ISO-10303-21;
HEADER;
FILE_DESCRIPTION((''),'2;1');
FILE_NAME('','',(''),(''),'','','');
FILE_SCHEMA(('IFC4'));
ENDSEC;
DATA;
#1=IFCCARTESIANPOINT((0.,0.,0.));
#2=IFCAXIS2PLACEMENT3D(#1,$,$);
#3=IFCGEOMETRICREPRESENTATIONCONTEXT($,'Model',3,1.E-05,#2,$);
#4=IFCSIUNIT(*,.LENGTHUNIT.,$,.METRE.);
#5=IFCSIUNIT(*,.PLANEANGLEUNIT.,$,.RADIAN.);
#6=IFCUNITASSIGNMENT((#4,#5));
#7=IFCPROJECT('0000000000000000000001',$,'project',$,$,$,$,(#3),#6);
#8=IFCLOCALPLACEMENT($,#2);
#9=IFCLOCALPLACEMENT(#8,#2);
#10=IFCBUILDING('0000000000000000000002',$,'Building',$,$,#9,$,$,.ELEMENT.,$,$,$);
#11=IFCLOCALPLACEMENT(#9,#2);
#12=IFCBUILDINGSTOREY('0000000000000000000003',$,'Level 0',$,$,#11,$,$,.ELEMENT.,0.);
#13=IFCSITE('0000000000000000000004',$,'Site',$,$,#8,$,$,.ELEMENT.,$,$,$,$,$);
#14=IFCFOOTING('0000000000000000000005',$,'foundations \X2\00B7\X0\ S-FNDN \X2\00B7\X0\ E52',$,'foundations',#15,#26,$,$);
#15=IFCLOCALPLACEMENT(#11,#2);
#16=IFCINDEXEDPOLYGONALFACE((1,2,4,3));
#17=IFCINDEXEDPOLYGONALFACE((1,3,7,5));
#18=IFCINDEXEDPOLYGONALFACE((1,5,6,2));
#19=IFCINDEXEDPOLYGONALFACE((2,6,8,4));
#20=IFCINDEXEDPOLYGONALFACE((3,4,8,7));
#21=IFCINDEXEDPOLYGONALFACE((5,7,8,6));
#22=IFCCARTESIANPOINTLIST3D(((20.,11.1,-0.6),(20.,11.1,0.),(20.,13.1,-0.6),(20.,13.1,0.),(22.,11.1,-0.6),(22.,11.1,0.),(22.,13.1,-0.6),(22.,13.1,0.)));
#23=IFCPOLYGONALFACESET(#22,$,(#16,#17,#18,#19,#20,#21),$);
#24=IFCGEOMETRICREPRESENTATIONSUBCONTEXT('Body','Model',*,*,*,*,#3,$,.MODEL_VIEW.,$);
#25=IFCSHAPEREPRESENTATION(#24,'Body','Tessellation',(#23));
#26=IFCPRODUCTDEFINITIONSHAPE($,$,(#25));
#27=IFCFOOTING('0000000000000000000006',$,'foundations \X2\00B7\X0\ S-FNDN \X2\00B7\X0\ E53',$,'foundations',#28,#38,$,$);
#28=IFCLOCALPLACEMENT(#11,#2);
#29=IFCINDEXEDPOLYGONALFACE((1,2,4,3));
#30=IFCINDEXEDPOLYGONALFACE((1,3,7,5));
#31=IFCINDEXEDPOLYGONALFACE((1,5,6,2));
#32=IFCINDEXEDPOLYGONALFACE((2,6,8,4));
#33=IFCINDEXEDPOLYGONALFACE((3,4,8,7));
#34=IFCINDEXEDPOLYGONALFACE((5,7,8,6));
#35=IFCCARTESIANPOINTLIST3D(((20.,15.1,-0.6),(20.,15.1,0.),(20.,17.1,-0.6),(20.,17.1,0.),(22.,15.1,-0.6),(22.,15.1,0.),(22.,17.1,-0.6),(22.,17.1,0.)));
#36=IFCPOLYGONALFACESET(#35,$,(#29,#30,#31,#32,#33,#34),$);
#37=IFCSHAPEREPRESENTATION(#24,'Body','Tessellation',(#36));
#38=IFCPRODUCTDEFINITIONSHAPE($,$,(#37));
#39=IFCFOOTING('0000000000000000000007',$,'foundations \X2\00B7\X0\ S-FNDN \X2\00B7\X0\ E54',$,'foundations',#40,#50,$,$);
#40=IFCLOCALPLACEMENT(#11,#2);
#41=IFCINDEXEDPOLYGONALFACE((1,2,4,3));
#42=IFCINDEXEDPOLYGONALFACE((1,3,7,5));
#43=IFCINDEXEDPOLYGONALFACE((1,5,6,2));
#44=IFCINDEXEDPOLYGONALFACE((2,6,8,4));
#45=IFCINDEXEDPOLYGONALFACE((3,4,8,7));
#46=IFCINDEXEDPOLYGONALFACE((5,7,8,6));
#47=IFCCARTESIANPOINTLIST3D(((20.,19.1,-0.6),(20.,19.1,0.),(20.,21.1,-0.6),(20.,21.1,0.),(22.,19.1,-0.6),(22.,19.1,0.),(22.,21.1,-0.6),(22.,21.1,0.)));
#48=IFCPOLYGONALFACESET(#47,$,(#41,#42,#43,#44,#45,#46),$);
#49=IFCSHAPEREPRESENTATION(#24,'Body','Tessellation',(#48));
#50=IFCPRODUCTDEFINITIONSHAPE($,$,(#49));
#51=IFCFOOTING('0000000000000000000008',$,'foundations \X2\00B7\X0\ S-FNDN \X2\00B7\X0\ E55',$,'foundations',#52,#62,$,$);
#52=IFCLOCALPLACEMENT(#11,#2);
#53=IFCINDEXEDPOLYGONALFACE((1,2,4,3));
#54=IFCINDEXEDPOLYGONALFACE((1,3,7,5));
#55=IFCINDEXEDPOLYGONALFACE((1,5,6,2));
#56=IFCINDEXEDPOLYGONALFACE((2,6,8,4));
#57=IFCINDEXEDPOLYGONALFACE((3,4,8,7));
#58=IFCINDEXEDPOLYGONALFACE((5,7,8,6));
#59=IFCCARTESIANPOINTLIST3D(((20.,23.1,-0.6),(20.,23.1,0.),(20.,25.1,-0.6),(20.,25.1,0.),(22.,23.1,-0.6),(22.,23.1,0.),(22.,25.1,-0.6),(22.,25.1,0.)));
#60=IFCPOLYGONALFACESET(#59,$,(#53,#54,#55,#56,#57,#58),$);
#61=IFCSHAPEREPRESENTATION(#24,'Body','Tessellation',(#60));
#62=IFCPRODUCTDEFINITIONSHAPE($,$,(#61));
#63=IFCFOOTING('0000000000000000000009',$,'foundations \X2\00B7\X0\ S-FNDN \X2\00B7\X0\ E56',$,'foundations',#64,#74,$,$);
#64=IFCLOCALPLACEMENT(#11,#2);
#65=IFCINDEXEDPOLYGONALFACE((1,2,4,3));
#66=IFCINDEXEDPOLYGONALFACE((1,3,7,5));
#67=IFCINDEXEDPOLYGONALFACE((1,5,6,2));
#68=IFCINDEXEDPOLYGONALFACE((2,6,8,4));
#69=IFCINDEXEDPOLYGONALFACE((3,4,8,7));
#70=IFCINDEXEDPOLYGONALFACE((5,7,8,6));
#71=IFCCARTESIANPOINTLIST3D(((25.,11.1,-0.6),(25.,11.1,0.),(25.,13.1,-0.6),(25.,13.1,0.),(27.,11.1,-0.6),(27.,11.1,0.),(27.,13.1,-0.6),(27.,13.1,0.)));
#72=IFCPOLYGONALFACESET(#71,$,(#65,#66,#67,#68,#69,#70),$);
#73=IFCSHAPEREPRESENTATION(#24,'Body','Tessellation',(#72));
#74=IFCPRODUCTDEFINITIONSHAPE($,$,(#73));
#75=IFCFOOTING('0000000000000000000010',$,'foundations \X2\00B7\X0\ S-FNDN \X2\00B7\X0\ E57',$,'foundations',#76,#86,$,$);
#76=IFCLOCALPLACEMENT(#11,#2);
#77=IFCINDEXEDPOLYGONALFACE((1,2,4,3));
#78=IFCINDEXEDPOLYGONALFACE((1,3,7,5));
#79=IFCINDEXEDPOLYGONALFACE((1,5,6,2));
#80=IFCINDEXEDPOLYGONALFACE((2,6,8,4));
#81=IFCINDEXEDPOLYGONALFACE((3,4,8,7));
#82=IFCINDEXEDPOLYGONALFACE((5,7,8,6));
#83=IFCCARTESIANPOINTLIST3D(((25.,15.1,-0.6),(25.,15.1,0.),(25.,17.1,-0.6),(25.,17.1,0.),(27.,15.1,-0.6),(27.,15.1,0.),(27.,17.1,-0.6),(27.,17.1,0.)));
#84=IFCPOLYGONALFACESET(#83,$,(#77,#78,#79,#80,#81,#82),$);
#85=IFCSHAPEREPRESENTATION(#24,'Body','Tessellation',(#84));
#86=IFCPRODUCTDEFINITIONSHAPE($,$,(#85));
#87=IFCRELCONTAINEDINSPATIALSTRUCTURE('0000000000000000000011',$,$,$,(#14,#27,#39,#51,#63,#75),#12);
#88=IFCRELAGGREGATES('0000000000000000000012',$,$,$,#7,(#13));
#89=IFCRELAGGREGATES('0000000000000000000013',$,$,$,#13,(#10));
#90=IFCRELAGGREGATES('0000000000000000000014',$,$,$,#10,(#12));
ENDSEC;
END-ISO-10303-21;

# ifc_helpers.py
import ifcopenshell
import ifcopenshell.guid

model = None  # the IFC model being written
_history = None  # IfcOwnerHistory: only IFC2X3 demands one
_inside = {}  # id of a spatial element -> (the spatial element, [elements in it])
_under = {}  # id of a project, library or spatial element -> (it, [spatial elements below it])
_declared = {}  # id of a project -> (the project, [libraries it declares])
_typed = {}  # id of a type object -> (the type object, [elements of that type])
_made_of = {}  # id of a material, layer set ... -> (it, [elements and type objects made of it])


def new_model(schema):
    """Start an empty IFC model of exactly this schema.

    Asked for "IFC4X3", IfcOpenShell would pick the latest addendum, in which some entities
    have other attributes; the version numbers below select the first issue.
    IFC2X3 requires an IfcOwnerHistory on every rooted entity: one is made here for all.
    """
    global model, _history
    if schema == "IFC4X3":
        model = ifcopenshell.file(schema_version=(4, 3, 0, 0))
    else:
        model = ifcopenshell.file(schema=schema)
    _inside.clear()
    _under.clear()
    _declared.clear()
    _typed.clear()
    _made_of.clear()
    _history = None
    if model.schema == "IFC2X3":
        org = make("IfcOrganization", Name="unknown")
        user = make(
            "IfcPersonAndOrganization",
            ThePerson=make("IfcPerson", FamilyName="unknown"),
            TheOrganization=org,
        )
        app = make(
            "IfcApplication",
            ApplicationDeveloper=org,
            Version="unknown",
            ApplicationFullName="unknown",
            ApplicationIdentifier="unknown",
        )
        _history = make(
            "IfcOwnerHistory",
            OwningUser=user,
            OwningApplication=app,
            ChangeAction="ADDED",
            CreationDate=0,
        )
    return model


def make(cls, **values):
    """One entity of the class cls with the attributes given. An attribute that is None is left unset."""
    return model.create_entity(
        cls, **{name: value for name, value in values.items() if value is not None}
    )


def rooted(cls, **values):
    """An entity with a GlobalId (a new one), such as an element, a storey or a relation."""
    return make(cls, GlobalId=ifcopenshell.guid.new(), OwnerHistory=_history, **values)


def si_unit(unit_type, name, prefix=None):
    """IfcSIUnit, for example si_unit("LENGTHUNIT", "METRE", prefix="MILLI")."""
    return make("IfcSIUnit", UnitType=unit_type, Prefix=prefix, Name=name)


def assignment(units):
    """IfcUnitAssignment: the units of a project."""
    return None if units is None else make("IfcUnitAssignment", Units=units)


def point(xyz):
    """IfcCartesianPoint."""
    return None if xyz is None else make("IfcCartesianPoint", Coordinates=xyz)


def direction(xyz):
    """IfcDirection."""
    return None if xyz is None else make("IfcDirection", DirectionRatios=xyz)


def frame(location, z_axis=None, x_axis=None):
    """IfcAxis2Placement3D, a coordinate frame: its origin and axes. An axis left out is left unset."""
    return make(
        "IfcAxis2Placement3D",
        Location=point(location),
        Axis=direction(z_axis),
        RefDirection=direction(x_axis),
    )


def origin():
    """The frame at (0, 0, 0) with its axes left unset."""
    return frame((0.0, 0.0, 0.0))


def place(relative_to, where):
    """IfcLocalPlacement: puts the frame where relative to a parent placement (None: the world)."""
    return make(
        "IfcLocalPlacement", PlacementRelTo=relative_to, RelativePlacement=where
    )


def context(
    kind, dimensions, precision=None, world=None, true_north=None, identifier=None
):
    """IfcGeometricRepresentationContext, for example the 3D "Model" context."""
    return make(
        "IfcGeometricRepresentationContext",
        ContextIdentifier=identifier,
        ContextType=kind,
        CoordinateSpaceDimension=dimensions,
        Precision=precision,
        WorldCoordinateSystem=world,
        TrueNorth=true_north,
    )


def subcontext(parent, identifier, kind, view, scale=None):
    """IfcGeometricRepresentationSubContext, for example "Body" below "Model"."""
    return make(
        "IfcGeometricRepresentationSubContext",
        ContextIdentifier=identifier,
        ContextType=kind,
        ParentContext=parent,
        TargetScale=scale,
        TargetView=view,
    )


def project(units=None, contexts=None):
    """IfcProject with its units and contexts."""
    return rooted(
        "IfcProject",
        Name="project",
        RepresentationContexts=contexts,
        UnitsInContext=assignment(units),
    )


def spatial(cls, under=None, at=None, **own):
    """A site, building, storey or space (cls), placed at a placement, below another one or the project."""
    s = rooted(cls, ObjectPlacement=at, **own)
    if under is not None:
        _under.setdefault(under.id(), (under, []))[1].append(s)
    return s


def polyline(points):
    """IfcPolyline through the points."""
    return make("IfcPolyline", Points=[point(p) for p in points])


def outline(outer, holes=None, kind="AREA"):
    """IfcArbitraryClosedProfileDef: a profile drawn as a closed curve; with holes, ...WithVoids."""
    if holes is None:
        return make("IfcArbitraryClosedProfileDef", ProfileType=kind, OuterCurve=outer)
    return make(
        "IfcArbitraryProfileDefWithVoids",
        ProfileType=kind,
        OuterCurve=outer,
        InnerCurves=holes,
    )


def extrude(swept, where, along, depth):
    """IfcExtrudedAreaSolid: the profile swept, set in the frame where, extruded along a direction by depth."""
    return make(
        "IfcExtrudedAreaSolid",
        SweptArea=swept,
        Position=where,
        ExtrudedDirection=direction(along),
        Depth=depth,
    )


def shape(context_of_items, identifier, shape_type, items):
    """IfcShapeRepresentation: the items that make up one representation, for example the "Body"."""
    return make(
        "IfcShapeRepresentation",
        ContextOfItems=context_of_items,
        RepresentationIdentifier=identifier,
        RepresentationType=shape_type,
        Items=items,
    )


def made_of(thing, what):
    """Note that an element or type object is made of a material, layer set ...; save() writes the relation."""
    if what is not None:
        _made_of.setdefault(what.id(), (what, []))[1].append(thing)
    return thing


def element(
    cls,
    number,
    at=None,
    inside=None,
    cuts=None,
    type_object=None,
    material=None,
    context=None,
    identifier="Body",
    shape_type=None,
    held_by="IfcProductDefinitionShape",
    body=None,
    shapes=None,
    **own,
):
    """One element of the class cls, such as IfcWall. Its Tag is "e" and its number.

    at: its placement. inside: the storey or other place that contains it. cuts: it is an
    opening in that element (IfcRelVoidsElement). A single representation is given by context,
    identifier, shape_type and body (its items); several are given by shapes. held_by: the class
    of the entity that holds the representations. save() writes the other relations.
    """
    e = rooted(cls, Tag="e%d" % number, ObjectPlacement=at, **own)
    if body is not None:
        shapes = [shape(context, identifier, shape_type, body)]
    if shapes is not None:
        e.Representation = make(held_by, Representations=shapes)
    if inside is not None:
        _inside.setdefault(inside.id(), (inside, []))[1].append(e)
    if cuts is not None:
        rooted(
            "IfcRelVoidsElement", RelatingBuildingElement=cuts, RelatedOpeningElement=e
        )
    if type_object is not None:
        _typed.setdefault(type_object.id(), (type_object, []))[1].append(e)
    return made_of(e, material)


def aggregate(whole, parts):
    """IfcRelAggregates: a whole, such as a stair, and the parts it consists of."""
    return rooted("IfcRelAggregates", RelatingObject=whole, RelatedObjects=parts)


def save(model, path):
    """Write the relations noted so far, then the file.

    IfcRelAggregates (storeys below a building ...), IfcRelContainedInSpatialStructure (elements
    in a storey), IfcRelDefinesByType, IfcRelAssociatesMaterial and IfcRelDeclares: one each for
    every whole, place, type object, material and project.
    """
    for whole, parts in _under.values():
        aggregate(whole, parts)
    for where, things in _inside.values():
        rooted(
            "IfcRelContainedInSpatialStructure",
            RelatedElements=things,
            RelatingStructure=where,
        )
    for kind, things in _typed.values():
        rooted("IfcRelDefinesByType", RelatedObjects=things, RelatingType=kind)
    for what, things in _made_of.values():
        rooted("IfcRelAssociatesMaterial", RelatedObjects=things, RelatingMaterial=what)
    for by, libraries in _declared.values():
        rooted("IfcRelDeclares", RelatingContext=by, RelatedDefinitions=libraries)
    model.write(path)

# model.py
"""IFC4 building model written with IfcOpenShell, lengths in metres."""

from ifc_helpers import new_model, si_unit, frame, origin, place, context, subcontext, project, spatial, polyline, outline, extrude, element, save


model = new_model("IFC4")

# Units and contexts
model_context = context("Model", 3, precision=1e-05, world=origin())
body_context = subcontext(model_context, "Body", "Model", "MODEL_VIEW")
ifc_project = project(units=[si_unit("LENGTHUNIT", "METRE"), si_unit("PLANEANGLEUNIT", "RADIAN")], contexts=[model_context])

# Site, building, storey
site_placement = place(None, origin())
site = spatial("IfcSite", under=ifc_project, at=site_placement, Name="Site", CompositionType="ELEMENT")
building_placement = place(site_placement, origin())
building = spatial("IfcBuilding", under=site, at=building_placement, Name="Building", CompositionType="ELEMENT")
storey_placement = place(building_placement, origin())
storey = spatial("IfcBuildingStorey", under=building, at=storey_placement, Name="Level 0", CompositionType="ELEMENT", Elevation=0.0)

# Footings
footing_1_placement = place(storey_placement, frame((0.0, 0.0, -0.6)))
element("IfcFooting", 1, at=footing_1_placement, inside=storey, Name="foundations · S-FNDN · E52", ObjectType="foundations", context=body_context, shape_type="SweptSolid", body=[
    extrude(outline(polyline([(20.0, 11.1), (22.0, 11.1), (22.0, 13.1), (20.0, 13.1), (20.0, 11.1)])), origin(), (0.0, 0.0, 1.0), 0.6),
])
footing_2_placement = place(storey_placement, frame((0.0, 0.0, -0.6)))
element("IfcFooting", 2, at=footing_2_placement, inside=storey, Name="foundations · S-FNDN · E53", ObjectType="foundations", context=body_context, shape_type="SweptSolid", body=[
    extrude(outline(polyline([(20.0, 15.1), (22.0, 15.1), (22.0, 17.1), (20.0, 17.1), (20.0, 15.1)])), origin(), (0.0, 0.0, 1.0), 0.6),
])
footing_3_placement = place(storey_placement, frame((0.0, 0.0, -0.6)))
element("IfcFooting", 3, at=footing_3_placement, inside=storey, Name="foundations · S-FNDN · E54", ObjectType="foundations", context=body_context, shape_type="SweptSolid", body=[
    extrude(outline(polyline([(20.0, 19.1), (22.0, 19.1), (22.0, 21.1), (20.0, 21.1), (20.0, 19.1)])), origin(), (0.0, 0.0, 1.0), 0.6),
])
footing_4_placement = place(storey_placement, frame((0.0, 0.0, -0.6)))
element("IfcFooting", 4, at=footing_4_placement, inside=storey, Name="foundations · S-FNDN · E55", ObjectType="foundations", context=body_context, shape_type="SweptSolid", body=[
    extrude(outline(polyline([(20.0, 23.1), (22.0, 23.1), (22.0, 25.1), (20.0, 25.1), (20.0, 23.1)])), origin(), (0.0, 0.0, 1.0), 0.6),
])
footing_5_placement = place(storey_placement, frame((0.0, 0.0, -0.6)))
element("IfcFooting", 5, at=footing_5_placement, inside=storey, Name="foundations · S-FNDN · E56", ObjectType="foundations", context=body_context, shape_type="SweptSolid", body=[
    extrude(outline(polyline([(25.0, 11.1), (27.0, 11.1), (27.0, 13.1), (25.0, 13.1), (25.0, 11.1)])), origin(), (0.0, 0.0, 1.0), 0.6),
])
footing_6_placement = place(storey_placement, frame((0.0, 0.0, -0.6)))
element("IfcFooting", 6, at=footing_6_placement, inside=storey, Name="foundations · S-FNDN · E57", ObjectType="foundations", context=body_context, shape_type="SweptSolid", body=[
    extrude(outline(polyline([(25.0, 15.1), (27.0, 15.1), (27.0, 17.1), (25.0, 17.1), (25.0, 15.1)])), origin(), (0.0, 0.0, 1.0), 0.6),
])

save(model, "model.ifc")
